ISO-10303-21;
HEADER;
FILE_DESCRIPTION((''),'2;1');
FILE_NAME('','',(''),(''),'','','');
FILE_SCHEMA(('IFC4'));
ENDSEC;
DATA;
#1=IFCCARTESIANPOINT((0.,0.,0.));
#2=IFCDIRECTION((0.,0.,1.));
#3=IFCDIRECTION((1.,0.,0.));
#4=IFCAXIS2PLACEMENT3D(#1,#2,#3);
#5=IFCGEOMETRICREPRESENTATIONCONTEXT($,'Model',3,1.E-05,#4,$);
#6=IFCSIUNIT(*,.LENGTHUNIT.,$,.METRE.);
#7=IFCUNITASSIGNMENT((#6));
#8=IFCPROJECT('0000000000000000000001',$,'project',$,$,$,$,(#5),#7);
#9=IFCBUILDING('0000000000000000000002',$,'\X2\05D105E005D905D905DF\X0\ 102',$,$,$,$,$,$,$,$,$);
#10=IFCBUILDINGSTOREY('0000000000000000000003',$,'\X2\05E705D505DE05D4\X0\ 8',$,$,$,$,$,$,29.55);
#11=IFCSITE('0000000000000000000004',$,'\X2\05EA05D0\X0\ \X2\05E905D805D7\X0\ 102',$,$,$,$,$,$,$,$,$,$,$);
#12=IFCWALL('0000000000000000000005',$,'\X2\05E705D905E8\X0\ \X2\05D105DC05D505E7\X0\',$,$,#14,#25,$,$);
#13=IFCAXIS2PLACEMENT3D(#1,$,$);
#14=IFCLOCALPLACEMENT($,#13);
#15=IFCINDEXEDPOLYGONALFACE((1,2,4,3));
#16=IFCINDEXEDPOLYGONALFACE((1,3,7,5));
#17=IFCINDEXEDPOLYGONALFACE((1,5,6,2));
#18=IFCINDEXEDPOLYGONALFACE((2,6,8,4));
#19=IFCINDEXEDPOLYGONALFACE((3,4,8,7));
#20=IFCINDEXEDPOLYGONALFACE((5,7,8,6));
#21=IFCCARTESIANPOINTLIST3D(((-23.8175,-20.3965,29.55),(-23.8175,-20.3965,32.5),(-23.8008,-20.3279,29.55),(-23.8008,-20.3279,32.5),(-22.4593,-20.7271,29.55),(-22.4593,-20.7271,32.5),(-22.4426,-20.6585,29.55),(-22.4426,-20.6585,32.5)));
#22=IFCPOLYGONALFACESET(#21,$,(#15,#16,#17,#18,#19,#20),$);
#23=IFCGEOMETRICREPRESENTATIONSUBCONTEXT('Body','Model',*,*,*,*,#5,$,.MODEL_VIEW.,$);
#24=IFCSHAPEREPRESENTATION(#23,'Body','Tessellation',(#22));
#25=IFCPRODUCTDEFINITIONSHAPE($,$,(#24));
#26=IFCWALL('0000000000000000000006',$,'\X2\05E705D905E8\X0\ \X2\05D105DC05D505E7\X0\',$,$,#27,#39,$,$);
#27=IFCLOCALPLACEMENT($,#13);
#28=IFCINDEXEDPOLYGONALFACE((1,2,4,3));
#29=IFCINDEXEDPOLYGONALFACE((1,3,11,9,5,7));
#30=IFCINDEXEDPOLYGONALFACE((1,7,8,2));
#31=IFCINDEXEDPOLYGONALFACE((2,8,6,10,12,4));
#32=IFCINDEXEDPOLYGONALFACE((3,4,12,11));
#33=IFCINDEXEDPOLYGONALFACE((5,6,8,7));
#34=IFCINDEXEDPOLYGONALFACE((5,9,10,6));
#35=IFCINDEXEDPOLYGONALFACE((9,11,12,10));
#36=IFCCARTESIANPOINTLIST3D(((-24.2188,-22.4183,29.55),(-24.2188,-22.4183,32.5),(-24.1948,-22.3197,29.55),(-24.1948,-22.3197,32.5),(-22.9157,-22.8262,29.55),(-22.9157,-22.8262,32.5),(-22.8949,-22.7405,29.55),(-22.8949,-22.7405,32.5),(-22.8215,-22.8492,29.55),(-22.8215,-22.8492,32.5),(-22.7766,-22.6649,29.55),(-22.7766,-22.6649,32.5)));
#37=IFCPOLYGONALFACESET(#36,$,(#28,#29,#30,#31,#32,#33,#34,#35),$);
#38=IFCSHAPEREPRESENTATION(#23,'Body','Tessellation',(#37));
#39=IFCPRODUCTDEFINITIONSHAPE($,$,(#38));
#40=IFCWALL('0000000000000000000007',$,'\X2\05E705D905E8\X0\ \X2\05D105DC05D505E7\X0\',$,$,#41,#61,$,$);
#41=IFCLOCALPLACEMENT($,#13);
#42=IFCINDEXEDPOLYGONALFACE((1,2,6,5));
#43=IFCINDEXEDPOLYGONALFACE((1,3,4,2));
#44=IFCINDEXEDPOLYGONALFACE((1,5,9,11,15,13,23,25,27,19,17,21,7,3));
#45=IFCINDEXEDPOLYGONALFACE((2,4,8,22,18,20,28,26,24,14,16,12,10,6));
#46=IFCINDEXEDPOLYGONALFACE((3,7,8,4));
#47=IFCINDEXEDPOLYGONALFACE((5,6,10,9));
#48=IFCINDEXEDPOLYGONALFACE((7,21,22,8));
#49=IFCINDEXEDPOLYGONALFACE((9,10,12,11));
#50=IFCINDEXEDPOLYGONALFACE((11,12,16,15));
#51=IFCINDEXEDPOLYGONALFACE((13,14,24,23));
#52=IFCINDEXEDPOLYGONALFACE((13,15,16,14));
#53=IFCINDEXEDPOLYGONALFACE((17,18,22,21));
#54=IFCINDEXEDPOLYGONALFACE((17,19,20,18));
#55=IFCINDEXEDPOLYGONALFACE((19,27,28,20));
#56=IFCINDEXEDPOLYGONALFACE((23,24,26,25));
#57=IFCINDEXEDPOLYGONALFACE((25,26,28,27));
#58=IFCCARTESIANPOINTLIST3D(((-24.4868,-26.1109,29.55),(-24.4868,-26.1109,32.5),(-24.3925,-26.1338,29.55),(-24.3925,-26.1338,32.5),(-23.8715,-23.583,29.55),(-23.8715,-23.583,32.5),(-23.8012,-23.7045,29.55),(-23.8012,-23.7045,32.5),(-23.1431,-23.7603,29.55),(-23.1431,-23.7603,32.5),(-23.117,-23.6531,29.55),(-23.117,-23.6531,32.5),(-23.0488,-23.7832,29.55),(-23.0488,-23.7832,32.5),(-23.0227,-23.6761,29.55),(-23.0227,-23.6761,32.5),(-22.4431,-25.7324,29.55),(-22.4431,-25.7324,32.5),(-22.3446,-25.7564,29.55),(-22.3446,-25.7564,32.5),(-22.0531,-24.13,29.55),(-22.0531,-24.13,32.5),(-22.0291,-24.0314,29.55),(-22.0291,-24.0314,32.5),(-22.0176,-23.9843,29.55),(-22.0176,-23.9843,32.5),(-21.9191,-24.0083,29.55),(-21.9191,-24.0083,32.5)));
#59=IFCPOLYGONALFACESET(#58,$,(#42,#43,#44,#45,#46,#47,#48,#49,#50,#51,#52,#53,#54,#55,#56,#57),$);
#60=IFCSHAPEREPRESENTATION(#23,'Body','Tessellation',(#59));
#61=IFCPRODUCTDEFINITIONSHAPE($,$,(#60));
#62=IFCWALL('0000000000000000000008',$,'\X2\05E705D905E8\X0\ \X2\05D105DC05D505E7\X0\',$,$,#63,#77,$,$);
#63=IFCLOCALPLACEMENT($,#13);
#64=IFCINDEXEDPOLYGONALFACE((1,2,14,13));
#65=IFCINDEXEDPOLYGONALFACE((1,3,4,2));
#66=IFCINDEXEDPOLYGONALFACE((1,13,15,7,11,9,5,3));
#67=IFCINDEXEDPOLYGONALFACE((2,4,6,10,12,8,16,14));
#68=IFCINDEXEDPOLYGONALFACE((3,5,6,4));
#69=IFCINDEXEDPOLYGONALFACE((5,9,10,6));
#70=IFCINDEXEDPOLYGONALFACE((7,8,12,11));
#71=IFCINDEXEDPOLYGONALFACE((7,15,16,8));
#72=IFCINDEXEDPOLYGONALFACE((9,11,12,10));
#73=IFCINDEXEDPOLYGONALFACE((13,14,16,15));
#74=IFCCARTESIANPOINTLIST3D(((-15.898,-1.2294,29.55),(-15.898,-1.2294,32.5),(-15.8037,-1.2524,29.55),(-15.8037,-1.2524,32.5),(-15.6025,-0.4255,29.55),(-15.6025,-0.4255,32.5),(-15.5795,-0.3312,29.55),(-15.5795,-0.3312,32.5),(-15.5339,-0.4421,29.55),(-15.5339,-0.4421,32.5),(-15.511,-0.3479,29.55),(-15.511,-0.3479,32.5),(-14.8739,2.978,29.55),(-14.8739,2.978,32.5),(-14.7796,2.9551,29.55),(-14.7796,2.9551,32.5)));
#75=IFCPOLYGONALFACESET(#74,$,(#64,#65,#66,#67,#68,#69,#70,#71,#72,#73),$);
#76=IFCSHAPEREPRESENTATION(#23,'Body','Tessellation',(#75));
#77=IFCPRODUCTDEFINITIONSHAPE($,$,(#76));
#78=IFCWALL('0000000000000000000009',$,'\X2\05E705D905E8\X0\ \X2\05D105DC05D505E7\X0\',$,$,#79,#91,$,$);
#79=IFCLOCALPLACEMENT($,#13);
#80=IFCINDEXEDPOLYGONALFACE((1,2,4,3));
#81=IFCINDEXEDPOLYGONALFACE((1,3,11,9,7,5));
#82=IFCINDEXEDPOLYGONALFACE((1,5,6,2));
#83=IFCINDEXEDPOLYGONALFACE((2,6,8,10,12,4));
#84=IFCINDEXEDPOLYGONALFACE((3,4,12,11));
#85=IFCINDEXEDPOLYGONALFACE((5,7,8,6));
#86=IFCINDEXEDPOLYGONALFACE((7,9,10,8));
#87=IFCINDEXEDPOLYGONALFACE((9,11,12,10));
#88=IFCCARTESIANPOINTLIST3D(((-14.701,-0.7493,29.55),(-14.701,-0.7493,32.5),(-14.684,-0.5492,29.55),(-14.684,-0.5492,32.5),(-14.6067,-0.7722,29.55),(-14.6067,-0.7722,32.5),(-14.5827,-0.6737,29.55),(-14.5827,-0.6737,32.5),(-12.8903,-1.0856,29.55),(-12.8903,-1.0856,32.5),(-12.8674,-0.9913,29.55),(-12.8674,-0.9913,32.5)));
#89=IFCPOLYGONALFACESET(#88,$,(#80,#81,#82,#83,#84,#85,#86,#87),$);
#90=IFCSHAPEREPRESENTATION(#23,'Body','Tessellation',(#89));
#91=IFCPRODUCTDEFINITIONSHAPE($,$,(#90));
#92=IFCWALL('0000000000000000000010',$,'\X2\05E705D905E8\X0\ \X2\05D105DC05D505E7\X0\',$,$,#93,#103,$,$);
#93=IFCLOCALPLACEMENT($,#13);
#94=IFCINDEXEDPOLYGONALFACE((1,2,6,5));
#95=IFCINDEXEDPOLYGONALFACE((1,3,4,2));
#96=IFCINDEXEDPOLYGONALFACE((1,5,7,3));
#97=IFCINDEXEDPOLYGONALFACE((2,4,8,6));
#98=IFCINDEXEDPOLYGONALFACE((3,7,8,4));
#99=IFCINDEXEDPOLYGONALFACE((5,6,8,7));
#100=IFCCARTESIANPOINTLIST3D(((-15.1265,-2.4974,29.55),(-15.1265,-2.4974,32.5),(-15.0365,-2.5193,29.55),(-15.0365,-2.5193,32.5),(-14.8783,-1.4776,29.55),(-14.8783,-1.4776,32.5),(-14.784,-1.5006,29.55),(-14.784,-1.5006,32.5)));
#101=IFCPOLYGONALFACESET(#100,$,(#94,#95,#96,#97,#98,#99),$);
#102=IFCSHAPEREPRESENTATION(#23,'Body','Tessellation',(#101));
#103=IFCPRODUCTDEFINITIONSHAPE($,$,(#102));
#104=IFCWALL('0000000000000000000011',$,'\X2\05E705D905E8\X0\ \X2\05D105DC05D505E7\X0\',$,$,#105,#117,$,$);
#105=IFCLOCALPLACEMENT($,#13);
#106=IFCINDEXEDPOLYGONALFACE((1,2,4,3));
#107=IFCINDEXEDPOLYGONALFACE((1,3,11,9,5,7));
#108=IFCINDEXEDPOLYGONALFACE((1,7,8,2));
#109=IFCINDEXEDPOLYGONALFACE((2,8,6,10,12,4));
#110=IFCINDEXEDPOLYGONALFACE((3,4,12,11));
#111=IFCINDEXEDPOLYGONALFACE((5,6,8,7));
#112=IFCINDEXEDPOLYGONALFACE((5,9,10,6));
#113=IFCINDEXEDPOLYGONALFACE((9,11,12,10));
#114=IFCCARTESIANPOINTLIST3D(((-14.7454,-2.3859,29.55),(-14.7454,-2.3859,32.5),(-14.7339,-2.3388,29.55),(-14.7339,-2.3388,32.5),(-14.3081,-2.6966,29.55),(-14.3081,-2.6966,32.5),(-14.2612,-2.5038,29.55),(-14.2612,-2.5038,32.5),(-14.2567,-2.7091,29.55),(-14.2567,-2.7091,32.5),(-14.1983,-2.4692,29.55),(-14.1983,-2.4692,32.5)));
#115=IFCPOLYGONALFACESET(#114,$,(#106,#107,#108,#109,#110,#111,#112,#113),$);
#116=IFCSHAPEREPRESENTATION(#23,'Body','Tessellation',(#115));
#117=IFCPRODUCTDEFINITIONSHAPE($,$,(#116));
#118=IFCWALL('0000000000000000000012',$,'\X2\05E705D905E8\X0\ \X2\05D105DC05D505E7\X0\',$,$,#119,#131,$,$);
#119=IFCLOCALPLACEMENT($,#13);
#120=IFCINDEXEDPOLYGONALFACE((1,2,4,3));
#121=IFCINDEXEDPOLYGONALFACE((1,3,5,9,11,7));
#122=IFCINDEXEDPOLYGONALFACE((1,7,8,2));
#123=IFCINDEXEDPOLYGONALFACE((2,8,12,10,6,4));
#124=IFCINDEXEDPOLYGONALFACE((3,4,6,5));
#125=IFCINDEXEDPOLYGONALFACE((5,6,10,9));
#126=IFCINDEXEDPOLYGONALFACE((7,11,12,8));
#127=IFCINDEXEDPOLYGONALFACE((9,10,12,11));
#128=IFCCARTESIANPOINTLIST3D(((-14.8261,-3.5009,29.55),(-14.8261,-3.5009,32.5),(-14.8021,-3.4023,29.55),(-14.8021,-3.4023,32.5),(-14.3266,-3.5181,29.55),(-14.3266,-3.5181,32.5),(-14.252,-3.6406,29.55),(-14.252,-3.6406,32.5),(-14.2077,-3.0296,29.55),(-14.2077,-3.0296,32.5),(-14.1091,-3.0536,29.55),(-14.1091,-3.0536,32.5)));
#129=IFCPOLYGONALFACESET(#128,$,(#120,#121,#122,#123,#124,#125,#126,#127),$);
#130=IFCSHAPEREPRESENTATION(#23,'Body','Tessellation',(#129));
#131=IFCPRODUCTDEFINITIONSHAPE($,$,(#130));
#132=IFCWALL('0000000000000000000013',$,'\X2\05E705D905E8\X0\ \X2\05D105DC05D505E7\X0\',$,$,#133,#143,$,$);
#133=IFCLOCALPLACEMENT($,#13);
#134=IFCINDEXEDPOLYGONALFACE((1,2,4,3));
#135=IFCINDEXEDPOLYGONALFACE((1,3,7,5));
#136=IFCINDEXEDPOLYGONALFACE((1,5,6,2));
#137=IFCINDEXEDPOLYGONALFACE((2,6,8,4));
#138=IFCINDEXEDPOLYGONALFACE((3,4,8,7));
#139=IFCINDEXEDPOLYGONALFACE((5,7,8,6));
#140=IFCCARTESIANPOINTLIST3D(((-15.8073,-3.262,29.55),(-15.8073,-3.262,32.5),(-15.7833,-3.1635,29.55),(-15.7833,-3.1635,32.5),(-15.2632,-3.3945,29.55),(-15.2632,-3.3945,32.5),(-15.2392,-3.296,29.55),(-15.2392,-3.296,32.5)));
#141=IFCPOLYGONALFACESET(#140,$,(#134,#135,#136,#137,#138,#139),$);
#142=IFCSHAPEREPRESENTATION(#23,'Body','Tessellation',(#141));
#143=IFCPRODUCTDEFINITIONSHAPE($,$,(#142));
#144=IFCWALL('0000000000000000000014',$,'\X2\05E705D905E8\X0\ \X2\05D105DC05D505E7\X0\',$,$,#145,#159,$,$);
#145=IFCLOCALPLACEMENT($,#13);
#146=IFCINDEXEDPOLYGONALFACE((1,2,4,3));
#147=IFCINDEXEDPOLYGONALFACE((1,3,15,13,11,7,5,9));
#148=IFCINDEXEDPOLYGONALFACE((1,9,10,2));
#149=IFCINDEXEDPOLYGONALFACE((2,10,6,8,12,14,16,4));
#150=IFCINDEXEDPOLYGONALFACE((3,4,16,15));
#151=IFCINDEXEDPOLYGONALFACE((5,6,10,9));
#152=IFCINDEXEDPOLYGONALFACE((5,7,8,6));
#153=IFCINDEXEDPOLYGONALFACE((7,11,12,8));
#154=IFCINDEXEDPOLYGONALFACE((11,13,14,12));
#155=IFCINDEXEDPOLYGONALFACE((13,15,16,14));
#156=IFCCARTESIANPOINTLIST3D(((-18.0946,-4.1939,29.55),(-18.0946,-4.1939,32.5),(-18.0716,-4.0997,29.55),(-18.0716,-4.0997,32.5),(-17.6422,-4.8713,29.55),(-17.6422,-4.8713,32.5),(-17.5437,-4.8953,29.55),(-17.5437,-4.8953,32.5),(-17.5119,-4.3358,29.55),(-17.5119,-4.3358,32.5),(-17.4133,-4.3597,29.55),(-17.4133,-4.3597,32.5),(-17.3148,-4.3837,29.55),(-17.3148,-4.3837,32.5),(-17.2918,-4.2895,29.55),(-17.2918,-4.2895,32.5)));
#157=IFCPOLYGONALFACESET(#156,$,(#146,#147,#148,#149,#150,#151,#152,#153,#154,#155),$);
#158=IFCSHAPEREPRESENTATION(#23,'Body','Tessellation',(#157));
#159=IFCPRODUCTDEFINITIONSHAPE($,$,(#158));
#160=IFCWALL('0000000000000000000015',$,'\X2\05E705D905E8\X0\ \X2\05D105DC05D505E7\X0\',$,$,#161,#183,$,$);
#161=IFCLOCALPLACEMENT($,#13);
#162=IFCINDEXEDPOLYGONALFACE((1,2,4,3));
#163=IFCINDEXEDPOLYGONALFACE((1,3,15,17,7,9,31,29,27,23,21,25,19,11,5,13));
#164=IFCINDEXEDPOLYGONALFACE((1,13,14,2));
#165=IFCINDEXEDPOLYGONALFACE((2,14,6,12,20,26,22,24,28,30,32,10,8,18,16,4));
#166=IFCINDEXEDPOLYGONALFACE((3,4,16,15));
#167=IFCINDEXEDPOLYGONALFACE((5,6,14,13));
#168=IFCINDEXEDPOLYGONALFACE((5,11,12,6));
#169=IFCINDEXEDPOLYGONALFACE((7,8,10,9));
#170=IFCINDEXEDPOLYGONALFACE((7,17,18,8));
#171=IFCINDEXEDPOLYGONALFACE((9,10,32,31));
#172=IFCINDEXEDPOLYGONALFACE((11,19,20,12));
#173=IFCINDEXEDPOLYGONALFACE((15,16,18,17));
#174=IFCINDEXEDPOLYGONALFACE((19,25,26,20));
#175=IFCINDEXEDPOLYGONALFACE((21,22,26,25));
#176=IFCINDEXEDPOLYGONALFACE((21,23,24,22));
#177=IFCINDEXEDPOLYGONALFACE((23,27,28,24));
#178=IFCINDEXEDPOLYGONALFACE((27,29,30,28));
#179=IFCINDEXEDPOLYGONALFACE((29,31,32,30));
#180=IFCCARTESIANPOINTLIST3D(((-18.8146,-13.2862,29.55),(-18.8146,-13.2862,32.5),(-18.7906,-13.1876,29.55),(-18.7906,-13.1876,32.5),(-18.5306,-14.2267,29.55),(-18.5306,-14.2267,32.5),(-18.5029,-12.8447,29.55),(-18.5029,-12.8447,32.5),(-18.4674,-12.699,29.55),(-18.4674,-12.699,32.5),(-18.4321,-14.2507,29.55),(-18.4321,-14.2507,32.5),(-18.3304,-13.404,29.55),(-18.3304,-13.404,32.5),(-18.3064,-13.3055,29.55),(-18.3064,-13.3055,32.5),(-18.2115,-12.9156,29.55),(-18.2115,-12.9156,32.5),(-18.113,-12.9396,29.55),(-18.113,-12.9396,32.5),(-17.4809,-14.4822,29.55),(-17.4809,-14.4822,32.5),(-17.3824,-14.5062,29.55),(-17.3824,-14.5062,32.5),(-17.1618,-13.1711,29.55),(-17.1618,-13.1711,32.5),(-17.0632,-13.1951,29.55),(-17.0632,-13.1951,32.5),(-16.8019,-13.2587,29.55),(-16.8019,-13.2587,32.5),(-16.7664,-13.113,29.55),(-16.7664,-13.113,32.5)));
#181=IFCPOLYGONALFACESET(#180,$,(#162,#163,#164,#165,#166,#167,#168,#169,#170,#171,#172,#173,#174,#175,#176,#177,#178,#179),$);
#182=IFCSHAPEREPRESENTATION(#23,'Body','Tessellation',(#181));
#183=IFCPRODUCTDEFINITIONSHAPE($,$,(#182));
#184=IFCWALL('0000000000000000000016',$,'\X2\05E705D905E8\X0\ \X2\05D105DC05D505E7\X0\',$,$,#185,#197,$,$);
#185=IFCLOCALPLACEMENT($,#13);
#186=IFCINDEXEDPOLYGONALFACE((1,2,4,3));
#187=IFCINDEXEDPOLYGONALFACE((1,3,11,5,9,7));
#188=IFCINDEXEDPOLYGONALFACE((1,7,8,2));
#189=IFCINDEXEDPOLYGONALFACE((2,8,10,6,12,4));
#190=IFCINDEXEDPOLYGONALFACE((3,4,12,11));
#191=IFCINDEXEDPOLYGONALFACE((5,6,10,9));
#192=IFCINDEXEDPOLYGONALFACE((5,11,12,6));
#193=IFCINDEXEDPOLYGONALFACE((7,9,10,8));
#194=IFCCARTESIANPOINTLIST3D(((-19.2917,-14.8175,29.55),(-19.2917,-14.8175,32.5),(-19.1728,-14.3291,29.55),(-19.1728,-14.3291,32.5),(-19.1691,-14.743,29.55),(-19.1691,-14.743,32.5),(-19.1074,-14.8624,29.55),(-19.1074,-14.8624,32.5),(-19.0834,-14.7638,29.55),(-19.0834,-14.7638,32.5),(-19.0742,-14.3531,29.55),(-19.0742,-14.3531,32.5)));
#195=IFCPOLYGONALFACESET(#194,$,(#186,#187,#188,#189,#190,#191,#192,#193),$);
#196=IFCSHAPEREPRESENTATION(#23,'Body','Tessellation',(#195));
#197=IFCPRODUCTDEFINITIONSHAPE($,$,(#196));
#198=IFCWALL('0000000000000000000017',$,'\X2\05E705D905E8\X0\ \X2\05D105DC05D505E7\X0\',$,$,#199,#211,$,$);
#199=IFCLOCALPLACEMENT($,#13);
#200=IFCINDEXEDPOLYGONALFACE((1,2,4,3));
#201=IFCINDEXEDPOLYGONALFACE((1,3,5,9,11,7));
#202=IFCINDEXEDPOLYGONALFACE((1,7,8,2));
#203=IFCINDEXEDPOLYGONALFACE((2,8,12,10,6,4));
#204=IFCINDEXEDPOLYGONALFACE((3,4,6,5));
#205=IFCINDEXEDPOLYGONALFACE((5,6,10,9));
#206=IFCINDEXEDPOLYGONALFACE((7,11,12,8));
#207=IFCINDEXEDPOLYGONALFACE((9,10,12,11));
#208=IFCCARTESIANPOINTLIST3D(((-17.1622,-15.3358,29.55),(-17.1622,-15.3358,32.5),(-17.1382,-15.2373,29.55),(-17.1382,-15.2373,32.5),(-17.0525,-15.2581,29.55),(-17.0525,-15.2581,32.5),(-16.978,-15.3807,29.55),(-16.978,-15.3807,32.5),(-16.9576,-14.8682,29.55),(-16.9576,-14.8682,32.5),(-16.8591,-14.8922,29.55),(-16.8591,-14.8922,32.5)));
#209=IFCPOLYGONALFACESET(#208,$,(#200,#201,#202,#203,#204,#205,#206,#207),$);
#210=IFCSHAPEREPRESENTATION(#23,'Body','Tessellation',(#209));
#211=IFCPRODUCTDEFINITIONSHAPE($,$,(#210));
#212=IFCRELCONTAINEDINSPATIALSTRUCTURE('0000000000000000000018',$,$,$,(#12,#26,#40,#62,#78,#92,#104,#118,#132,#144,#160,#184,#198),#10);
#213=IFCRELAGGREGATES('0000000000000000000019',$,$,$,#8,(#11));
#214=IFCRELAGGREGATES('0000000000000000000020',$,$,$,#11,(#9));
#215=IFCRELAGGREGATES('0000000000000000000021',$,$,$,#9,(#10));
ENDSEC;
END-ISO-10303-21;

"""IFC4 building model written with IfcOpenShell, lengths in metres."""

from ifc_helpers import new_model, si_unit, frame, origin_with_axes, context, subcontext, project, spatial, polyline, outline, extrude, element, save


model = new_model("IFC4")

# Units and contexts
model_context = context("Model", 3, precision=1e-05, world=origin_with_axes())
body_context = subcontext(model_context, "Body", "Model", "MODEL_VIEW")
ifc_project = project(units=[si_unit("LENGTHUNIT", "METRE")], contexts=[model_context])

# Site, building, storey
site = spatial("IfcSite", under=ifc_project, Name="תא שטח 102")
building = spatial("IfcBuilding", under=site, Name="בניין 102")
storey = spatial("IfcBuildingStorey", under=building, Name="קומה 8", Elevation=29.55)

# Walls
element("IfcWall", 1, inside=storey, Name="קיר בלוק", context=body_context, shape_type="SweptSolid", body=[
    extrude(outline(polyline([(-22.4426, -20.6585), (-23.8008, -20.3279), (-23.8175, -20.3965), (-22.4593, -20.7271), (-22.4426, -20.6585)])), frame((0.0, 0.0, 29.55)), (0.0, 0.0, 1.0), 2.95),
])
element("IfcWall", 2, inside=storey, Name="קיר בלוק", context=body_context, shape_type="SweptSolid", body=[
    extrude(outline(polyline([(-24.2188, -22.4183), (-22.8949, -22.7405), (-22.9157, -22.8262), (-22.8215, -22.8492), (-22.7766, -22.6649), (-24.1948, -22.3197), (-24.2188, -22.4183)])), frame((0.0, 0.0, 29.55)), (0.0, 0.0, 1.0), 2.95),
])
element("IfcWall", 3, inside=storey, Name="קיר בלוק", context=body_context, shape_type="SweptSolid", body=[
    extrude(outline(polyline([(-23.8012, -23.7045), (-22.0531, -24.13), (-22.4431, -25.7324), (-22.3446, -25.7564), (-21.9191, -24.0083), (-22.0176, -23.9843), (-22.0291, -24.0314), (-23.0488, -23.7832), (-23.0227, -23.6761), (-23.117, -23.6531), (-23.1431, -23.7603), (-23.8715, -23.583), (-24.4868, -26.1109), (-24.3925, -26.1338), (-23.8012, -23.7045)])), frame((0.0, 0.0, 29.55)), (0.0, 0.0, 1.0), 2.95),
])
element("IfcWall", 4, inside=storey, Name="קיר בלוק", context=body_context, shape_type="SweptSolid", body=[
    extrude(outline(polyline([(-14.8739, 2.978), (-15.898, -1.2294), (-15.8037, -1.2524), (-15.6025, -0.4255), (-15.5339, -0.4421), (-15.511, -0.3479), (-15.5795, -0.3312), (-14.7796, 2.9551), (-14.8739, 2.978)])), frame((0.0, 0.0, 29.55)), (0.0, 0.0, 1.0), 2.95),
])
element("IfcWall", 5, inside=storey, Name="קיר בלוק", context=body_context, shape_type="SweptSolid", body=[
    extrude(outline(polyline([(-14.701, -0.7493), (-14.6067, -0.7722), (-14.5827, -0.6737), (-12.8903, -1.0856), (-12.8674, -0.9913), (-14.684, -0.5492), (-14.701, -0.7493)])), frame((0.0, 0.0, 29.55)), (0.0, 0.0, 1.0), 2.95),
])
element("IfcWall", 6, inside=storey, Name="קיר בלוק", context=body_context, shape_type="SweptSolid", body=[
    extrude(outline(polyline([(-15.1265, -2.4974), (-15.0365, -2.5193), (-14.784, -1.5006), (-14.8783, -1.4776), (-15.1265, -2.4974)])), frame((0.0, 0.0, 29.55)), (0.0, 0.0, 1.0), 2.95),
])
element("IfcWall", 7, inside=storey, Name="קיר בלוק", context=body_context, shape_type="SweptSolid", body=[
    extrude(outline(polyline([(-14.7454, -2.3859), (-14.2612, -2.5038), (-14.3081, -2.6966), (-14.2567, -2.7091), (-14.1983, -2.4692), (-14.7339, -2.3388), (-14.7454, -2.3859)])), frame((0.0, 0.0, 29.55)), (0.0, 0.0, 1.0), 2.95),
])
element("IfcWall", 8, inside=storey, Name="קיר בלוק", context=body_context, shape_type="SweptSolid", body=[
    extrude(outline(polyline([(-14.8021, -3.4023), (-14.8261, -3.5009), (-14.252, -3.6406), (-14.1091, -3.0536), (-14.2077, -3.0296), (-14.3266, -3.5181), (-14.8021, -3.4023)])), frame((0.0, 0.0, 29.55)), (0.0, 0.0, 1.0), 2.95),
])
element("IfcWall", 9, inside=storey, Name="קיר בלוק", context=body_context, shape_type="SweptSolid", body=[
    extrude(outline(polyline([(-15.7833, -3.1635), (-15.8073, -3.262), (-15.2632, -3.3945), (-15.2392, -3.296), (-15.7833, -3.1635)])), frame((0.0, 0.0, 29.55)), (0.0, 0.0, 1.0), 2.95),
])
element("IfcWall", 10, inside=storey, Name="קיר בלוק", context=body_context, shape_type="SweptSolid", body=[
    extrude(outline(polyline([(-17.4133, -4.3597), (-17.3148, -4.3837), (-17.2918, -4.2895), (-18.0716, -4.0997), (-18.0946, -4.1939), (-17.5119, -4.3358), (-17.6422, -4.8713), (-17.5437, -4.8953), (-17.4133, -4.3597)])), frame((0.0, 0.0, 29.55)), (0.0, 0.0, 1.0), 2.95),
])
element("IfcWall", 11, inside=storey, Name="קיר בלוק", context=body_context, shape_type="SweptSolid", body=[
    extrude(outline(polyline([(-18.7906, -13.1876), (-18.8146, -13.2862), (-18.3304, -13.404), (-18.5306, -14.2267), (-18.4321, -14.2507), (-18.113, -12.9396), (-17.1618, -13.1711), (-17.4809, -14.4822), (-17.3824, -14.5062), (-17.0632, -13.1951), (-16.8019, -13.2587), (-16.7664, -13.113), (-18.4674, -12.699), (-18.5029, -12.8447), (-18.2115, -12.9156), (-18.3064, -13.3055), (-18.7906, -13.1876)])), frame((0.0, 0.0, 29.55)), (0.0, 0.0, 1.0), 2.95),
])
element("IfcWall", 12, inside=storey, Name="קיר בלוק", context=body_context, shape_type="SweptSolid", body=[
    extrude(outline(polyline([(-19.0834, -14.7638), (-19.1691, -14.743), (-19.0742, -14.3531), (-19.1728, -14.3291), (-19.2917, -14.8175), (-19.1074, -14.8624), (-19.0834, -14.7638)])), frame((0.0, 0.0, 29.55)), (0.0, 0.0, 1.0), 2.95),
])
element("IfcWall", 13, inside=storey, Name="קיר בלוק", context=body_context, shape_type="SweptSolid", body=[
    extrude(outline(polyline([(-16.978, -15.3807), (-16.8591, -14.8922), (-16.9576, -14.8682), (-17.0525, -15.2581), (-17.1382, -15.2373), (-17.1622, -15.3358), (-16.978, -15.3807)])), frame((0.0, 0.0, 29.55)), (0.0, 0.0, 1.0), 2.95),
])

save(model, "model.ifc")
